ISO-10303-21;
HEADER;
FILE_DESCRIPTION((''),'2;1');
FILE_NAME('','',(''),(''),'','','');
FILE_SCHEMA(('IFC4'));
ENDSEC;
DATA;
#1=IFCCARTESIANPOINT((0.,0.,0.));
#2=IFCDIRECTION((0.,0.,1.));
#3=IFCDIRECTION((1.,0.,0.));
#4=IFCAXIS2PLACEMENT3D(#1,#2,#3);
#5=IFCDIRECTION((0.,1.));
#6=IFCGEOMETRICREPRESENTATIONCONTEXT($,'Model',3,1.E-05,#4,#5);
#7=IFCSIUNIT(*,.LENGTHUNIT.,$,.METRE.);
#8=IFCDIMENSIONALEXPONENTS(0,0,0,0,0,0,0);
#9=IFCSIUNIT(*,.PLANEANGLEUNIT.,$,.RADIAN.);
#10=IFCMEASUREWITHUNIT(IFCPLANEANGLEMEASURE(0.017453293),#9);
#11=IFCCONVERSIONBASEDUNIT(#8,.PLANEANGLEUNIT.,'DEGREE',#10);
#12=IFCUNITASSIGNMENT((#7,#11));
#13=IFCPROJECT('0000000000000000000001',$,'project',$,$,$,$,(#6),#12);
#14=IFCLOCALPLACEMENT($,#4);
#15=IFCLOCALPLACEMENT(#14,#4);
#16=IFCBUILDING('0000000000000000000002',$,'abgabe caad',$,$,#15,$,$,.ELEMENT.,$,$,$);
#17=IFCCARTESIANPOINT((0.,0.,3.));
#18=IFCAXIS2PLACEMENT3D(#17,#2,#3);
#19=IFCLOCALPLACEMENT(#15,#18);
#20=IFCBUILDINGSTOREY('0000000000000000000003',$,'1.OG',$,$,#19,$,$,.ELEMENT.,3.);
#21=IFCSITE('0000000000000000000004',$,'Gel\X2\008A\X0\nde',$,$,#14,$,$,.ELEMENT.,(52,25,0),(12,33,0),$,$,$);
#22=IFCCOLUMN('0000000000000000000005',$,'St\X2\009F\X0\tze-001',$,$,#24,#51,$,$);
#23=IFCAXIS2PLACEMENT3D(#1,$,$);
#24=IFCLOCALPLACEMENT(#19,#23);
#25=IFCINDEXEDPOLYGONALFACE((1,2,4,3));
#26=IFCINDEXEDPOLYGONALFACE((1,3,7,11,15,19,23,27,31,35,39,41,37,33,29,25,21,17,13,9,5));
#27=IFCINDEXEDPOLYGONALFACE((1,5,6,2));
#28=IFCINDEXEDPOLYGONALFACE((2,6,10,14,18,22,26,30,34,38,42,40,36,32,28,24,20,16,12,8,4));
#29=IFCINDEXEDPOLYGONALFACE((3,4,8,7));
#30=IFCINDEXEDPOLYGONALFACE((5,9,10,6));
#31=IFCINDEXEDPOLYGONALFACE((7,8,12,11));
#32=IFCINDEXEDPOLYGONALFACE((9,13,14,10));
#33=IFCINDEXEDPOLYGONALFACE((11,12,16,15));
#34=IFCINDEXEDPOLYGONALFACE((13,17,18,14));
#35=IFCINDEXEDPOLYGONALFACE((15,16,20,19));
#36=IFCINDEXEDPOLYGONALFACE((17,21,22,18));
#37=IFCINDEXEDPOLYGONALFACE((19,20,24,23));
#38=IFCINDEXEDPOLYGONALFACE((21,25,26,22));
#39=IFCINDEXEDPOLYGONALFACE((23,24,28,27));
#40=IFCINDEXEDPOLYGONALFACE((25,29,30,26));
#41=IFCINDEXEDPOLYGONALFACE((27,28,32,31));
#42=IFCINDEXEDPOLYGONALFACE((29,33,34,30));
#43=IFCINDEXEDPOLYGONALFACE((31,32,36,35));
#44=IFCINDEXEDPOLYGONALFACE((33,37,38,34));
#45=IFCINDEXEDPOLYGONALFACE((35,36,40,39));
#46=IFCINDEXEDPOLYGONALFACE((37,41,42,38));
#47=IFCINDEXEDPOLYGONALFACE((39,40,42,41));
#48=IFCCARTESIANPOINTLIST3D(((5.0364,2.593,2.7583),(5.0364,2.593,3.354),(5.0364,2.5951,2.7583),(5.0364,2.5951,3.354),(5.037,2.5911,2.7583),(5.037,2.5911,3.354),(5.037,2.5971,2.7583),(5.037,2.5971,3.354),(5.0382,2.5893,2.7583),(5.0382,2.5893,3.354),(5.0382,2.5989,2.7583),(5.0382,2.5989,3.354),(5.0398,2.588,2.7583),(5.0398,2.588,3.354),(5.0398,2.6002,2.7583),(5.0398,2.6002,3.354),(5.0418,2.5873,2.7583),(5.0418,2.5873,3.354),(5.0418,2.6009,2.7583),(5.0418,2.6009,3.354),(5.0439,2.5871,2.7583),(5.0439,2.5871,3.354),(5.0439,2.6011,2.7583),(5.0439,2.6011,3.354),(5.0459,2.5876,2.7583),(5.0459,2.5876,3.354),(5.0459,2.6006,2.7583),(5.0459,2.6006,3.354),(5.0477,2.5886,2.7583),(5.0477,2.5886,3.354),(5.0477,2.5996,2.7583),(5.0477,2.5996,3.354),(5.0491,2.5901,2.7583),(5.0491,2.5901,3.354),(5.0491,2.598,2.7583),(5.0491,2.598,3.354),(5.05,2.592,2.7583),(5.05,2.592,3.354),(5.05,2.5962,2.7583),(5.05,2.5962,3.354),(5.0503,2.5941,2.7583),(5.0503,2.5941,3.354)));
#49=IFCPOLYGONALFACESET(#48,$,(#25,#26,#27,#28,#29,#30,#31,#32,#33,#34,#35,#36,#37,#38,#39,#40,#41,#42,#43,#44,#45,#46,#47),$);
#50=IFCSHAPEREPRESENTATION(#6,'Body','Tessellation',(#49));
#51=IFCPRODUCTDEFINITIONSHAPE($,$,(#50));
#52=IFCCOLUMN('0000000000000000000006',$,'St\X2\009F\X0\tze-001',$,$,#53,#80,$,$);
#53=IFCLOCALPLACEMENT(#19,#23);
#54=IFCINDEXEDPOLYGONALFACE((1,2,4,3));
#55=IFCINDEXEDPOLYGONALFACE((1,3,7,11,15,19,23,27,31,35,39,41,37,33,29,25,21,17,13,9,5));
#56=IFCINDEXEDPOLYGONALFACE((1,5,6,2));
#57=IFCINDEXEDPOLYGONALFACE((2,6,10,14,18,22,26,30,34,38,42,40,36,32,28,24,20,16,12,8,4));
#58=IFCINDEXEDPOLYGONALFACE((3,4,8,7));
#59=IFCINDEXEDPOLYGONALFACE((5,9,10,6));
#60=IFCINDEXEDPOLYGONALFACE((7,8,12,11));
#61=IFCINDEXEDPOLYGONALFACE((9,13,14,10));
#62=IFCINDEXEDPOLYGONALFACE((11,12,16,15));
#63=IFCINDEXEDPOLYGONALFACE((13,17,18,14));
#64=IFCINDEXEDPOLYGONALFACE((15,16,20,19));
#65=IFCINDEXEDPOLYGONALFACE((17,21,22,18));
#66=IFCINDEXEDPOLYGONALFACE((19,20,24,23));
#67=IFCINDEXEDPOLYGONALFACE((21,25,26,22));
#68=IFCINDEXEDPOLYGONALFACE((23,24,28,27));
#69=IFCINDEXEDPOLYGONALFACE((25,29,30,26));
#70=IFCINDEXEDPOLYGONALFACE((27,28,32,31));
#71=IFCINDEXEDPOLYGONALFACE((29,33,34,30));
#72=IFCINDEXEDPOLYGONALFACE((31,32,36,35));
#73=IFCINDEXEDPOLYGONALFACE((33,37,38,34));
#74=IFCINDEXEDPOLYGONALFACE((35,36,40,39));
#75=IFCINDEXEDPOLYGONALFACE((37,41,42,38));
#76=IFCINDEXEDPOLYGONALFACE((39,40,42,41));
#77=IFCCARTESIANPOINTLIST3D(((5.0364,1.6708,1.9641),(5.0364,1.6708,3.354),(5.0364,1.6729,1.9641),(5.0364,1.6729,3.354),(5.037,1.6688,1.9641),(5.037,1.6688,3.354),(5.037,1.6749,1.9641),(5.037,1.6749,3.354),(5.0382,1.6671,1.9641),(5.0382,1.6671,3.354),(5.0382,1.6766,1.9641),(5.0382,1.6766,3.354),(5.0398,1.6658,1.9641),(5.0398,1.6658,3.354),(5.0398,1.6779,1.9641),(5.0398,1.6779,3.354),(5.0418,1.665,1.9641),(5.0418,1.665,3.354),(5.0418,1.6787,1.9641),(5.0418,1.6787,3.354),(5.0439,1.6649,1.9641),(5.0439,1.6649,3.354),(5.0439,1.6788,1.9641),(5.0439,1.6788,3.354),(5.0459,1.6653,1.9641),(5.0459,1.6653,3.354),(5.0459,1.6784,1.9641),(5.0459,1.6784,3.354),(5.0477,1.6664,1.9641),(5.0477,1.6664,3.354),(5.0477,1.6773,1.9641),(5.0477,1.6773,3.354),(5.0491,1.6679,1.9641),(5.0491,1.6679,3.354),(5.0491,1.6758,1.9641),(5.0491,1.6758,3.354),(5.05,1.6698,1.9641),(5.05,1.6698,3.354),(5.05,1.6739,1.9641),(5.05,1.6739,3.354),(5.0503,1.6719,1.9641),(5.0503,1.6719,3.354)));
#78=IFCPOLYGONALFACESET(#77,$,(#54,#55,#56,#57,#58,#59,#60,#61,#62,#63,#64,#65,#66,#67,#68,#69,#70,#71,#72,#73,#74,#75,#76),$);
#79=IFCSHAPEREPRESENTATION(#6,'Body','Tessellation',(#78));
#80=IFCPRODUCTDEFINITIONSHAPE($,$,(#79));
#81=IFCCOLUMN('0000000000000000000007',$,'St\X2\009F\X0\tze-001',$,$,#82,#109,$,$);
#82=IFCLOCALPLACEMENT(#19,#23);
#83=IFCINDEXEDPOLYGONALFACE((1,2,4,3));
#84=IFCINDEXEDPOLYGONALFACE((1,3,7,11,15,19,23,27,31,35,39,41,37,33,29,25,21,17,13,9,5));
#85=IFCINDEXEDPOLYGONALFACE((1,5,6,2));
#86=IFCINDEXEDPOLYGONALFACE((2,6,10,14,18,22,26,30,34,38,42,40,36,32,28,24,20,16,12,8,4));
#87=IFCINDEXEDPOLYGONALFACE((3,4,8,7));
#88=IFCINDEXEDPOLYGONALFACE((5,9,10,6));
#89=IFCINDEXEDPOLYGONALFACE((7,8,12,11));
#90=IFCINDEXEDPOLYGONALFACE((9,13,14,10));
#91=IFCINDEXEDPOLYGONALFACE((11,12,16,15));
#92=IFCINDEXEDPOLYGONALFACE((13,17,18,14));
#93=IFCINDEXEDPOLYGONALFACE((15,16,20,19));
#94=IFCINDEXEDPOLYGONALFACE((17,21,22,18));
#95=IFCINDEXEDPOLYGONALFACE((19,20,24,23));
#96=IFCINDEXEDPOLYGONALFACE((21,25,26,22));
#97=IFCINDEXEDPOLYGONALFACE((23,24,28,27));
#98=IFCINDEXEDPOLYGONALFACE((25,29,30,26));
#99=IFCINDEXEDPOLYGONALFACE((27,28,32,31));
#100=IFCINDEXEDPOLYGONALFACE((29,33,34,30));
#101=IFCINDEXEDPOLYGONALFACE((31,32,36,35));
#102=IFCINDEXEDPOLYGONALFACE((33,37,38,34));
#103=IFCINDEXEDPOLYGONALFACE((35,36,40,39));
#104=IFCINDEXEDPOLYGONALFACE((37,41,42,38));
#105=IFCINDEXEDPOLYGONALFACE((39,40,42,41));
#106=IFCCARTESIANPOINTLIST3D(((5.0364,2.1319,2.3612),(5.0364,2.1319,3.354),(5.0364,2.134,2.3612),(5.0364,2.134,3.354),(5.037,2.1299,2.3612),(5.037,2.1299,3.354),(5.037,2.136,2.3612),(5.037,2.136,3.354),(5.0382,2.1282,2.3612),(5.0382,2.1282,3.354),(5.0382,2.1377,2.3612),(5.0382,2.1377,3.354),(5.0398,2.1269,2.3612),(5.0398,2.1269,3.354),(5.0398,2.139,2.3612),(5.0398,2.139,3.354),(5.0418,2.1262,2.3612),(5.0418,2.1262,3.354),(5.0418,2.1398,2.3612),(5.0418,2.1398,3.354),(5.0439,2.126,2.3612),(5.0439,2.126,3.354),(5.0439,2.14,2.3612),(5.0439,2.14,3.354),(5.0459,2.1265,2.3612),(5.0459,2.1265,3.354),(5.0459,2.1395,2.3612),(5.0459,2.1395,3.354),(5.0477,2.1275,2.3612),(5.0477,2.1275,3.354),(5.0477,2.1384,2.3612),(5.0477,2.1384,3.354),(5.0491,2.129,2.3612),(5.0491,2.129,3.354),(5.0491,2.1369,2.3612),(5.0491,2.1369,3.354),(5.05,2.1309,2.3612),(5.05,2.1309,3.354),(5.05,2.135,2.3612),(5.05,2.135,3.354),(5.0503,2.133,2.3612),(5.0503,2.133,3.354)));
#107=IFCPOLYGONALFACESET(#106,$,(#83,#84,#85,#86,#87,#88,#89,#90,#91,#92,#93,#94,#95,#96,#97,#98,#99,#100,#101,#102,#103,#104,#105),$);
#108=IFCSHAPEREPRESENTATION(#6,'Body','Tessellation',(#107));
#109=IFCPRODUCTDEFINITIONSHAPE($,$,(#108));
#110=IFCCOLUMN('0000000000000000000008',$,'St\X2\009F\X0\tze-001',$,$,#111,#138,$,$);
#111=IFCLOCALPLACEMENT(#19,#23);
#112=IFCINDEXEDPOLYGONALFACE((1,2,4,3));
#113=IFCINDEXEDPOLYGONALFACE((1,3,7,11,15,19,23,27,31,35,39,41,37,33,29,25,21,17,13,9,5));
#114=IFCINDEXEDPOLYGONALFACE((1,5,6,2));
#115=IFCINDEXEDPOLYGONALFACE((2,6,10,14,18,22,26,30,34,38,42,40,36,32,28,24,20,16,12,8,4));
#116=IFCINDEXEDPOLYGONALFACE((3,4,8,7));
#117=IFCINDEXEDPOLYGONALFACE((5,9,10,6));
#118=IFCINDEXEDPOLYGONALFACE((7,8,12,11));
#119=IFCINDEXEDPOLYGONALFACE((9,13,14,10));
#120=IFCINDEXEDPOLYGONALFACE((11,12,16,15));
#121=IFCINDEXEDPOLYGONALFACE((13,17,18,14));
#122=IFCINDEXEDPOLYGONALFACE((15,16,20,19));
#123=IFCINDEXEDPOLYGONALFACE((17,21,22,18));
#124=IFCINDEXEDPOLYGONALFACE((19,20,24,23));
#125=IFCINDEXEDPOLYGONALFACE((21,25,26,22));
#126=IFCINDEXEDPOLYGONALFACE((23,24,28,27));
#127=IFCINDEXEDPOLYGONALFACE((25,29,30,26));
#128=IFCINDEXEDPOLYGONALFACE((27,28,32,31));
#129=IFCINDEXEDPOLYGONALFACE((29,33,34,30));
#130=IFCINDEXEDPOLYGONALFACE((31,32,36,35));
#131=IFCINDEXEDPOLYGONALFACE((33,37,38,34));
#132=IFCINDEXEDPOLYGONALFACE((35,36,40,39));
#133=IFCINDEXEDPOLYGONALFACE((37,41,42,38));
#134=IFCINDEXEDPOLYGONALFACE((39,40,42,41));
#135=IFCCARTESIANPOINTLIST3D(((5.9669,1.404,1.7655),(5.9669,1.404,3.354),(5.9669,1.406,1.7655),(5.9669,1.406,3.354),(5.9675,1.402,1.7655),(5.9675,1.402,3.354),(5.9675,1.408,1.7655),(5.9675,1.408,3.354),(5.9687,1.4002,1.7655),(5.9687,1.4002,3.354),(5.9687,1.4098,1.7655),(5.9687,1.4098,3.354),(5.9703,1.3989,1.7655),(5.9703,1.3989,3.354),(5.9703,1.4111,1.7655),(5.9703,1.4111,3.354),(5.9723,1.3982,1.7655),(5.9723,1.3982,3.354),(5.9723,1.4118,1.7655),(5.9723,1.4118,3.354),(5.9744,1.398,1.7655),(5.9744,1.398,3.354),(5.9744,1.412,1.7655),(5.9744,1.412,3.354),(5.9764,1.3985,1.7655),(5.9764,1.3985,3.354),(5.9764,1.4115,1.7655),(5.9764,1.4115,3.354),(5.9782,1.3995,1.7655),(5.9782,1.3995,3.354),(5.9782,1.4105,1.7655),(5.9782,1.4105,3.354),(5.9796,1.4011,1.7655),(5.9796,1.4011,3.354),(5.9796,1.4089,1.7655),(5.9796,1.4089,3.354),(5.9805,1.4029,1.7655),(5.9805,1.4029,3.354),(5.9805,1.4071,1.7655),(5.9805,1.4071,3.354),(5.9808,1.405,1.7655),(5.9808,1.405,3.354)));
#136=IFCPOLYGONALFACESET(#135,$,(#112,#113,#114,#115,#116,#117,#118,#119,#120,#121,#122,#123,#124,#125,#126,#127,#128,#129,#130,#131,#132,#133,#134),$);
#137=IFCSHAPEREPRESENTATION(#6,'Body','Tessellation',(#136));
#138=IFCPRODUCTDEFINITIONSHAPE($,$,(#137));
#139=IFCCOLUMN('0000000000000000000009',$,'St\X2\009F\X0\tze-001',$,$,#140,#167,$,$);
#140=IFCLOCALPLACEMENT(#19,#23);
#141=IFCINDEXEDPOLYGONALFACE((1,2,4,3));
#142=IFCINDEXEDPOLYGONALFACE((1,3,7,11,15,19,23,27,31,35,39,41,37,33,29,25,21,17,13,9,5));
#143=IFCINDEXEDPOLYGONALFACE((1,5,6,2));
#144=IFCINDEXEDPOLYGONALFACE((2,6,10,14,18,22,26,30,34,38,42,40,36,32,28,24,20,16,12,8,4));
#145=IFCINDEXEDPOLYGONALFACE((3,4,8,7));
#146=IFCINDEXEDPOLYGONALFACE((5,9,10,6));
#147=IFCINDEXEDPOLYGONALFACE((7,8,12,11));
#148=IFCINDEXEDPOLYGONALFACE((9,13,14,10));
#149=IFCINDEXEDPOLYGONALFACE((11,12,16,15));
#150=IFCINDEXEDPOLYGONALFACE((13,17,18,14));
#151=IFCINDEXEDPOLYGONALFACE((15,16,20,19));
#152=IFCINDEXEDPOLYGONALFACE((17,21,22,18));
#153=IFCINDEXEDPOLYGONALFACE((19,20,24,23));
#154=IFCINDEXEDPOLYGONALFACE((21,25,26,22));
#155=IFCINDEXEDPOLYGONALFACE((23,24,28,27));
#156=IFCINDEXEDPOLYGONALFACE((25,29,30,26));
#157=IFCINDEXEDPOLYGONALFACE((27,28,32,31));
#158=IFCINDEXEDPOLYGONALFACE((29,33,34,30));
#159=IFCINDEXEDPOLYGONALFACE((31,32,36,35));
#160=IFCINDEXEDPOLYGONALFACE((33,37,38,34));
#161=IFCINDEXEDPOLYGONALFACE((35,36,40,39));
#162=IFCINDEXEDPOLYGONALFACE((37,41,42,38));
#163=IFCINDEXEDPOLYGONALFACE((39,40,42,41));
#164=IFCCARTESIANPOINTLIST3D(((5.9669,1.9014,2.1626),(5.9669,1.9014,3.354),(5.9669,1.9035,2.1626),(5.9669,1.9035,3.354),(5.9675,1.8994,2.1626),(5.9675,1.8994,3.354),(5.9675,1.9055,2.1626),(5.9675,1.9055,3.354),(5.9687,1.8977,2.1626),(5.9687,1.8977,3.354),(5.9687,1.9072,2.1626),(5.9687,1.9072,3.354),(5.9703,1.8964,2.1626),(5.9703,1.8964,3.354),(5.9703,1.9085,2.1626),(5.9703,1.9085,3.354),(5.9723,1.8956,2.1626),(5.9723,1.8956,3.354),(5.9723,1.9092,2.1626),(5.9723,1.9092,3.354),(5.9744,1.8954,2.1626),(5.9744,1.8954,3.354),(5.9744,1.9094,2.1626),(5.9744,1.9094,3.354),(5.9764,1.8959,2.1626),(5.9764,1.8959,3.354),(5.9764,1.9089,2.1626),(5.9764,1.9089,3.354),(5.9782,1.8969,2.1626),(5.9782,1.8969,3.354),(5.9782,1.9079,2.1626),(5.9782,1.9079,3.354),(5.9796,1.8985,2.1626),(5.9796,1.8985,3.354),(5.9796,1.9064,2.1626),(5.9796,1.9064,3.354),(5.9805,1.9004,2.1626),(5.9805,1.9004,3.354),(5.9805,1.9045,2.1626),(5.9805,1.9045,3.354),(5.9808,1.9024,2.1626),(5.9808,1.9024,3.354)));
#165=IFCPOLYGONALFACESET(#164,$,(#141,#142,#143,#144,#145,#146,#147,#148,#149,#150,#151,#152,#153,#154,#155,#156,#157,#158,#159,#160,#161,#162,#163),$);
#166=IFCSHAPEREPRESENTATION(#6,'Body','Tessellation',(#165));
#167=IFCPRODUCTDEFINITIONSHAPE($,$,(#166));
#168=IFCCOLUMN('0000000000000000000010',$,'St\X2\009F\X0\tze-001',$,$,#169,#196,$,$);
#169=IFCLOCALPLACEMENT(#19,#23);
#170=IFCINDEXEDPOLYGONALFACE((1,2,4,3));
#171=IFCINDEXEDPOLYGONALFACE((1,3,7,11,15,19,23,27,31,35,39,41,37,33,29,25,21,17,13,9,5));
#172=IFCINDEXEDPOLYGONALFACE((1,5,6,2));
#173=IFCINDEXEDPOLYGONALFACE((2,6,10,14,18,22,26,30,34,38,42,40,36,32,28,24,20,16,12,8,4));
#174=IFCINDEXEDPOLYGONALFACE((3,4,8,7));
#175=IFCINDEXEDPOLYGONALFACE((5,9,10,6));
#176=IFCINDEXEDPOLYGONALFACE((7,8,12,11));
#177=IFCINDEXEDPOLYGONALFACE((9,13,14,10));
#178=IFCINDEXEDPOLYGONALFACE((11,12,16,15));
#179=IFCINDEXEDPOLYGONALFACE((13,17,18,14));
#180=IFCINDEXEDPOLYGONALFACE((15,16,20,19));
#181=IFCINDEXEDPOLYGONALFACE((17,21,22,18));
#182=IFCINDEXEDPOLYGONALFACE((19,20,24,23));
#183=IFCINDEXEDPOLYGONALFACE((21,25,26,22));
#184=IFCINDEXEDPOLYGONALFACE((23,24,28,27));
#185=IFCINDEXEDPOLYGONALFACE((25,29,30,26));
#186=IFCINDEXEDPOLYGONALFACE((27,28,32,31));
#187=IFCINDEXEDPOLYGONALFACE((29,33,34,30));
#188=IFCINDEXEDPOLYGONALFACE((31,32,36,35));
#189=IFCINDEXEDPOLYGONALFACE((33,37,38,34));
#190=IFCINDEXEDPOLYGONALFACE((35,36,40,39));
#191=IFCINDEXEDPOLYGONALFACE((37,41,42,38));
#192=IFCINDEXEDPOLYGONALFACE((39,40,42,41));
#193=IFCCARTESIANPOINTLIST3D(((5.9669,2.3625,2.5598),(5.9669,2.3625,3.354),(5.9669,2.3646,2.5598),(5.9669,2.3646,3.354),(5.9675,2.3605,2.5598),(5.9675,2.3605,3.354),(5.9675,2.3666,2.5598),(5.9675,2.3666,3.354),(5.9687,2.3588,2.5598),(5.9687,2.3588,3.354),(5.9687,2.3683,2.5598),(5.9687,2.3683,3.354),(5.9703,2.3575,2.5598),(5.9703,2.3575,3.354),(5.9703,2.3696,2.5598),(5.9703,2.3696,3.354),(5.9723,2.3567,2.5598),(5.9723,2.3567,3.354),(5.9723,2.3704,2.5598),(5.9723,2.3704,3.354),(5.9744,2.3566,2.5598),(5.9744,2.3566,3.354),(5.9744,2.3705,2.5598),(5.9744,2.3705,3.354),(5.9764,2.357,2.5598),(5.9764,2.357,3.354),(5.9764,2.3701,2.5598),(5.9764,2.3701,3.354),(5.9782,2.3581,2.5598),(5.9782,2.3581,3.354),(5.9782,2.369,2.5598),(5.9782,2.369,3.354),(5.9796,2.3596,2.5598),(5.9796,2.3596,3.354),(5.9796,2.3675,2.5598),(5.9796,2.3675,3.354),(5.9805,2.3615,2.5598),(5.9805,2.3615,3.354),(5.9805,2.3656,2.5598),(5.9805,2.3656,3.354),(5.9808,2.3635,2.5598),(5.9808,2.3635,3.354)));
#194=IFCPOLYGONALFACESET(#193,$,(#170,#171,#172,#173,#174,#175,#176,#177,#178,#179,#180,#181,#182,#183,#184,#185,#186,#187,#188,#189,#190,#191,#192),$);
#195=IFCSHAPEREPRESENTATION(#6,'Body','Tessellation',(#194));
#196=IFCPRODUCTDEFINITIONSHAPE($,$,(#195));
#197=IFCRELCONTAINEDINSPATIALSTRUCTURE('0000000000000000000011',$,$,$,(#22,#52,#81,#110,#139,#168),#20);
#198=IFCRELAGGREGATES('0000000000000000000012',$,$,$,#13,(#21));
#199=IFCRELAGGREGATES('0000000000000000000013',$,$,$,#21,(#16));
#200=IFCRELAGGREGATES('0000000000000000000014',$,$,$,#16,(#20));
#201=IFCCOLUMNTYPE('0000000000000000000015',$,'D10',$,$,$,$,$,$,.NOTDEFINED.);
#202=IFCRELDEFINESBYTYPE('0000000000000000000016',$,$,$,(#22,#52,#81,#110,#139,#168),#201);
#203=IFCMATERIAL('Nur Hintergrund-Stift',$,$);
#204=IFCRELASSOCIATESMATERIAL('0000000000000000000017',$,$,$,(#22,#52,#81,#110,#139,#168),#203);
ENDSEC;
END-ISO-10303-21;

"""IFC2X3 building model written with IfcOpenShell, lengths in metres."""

from ifc_helpers import new_model, entity, si_unit, converted_unit, direction, frame, origin_with_axes, origin_2d_with_axis, place, context, project, spatial, circle, extrude, material, type_object, element, save


model = new_model("IFC2X3")

# Units and contexts
model_context = context("Model", 3, precision=1e-05, world=origin_with_axes(), true_north=direction((0.0, 1.0)))
ifc_project = project(units=[si_unit("LENGTHUNIT", "METRE"), converted_unit("PLANEANGLEUNIT", "DEGREE", entity("IfcPlaneAngleMeasure", 0.017453293), si_unit("PLANEANGLEUNIT", "RADIAN"), dimensions=[0, 0, 0, 0, 0, 0, 0])], contexts=[model_context])

# Site, building, storey
site_placement = place(None, origin_with_axes())
site = spatial("IfcSite", under=ifc_project, at=site_placement, Name="Gel\u008ande", CompositionType="ELEMENT", RefLatitude=(52, 25, 0), RefLongitude=(12, 33, 0))
building_placement = place(site_placement, origin_with_axes())
building = spatial("IfcBuilding", under=site, at=building_placement, Name="abgabe caad", CompositionType="ELEMENT")
storey_placement = place(building_placement, frame((0.0, 0.0, 3.0), z_axis=(0.0, 0.0, 1.0), x_axis=(1.0, 0.0, 0.0)))
storey = spatial("IfcBuildingStorey", under=building, at=storey_placement, Name="1.OG", CompositionType="ELEMENT", Elevation=3.0)

# Columns
ifc_material_1 = material(Name="Nur Hintergrund-Stift")
column_type = type_object("IfcColumnType", Name="D10", PredefinedType="NOTDEFINED")
column_1_placement = place(storey_placement, frame((5.0433, 2.5941, 2.7583), z_axis=(0.0, 0.0, 1.0), x_axis=(1.0, 0.0, 0.0)))
element("IfcColumn", 1, at=column_1_placement, inside=storey, type_object=column_type, material=ifc_material_1, Name="St\u009ftze-001", context=model_context, shape_type="SweptSolid", body=[
    extrude(circle(Radius=0.007, at=origin_2d_with_axis()), origin_with_axes(), (0.0, 0.0, 1.0), 0.5957),
])
column_2_placement = place(storey_placement, frame((5.0433, 1.6719, 1.9641), z_axis=(0.0, 0.0, 1.0), x_axis=(1.0, 0.0, 0.0)))
element("IfcColumn", 2, at=column_2_placement, inside=storey, type_object=column_type, material=ifc_material_1, Name="St\u009ftze-001", context=model_context, shape_type="SweptSolid", body=[
    extrude(circle(Radius=0.007, at=origin_2d_with_axis()), origin_with_axes(), (0.0, 0.0, 1.0), 1.3899),
])
column_3_placement = place(storey_placement, frame((5.0433, 2.133, 2.3612), z_axis=(0.0, 0.0, 1.0), x_axis=(1.0, 0.0, 0.0)))
element("IfcColumn", 3, at=column_3_placement, inside=storey, type_object=column_type, material=ifc_material_1, Name="St\u009ftze-001", context=model_context, shape_type="SweptSolid", body=[
    extrude(circle(Radius=0.007, at=origin_2d_with_axis()), origin_with_axes(), (0.0, 0.0, 1.0), 0.9928),
])
column_4_placement = place(storey_placement, frame((5.9738, 1.405, 1.7655), z_axis=(0.0, 0.0, 1.0), x_axis=(1.0, 0.0, 0.0)))
element("IfcColumn", 4, at=column_4_placement, inside=storey, type_object=column_type, material=ifc_material_1, Name="St\u009ftze-001", context=model_context, shape_type="SweptSolid", body=[
    extrude(circle(Radius=0.007, at=origin_2d_with_axis()), origin_with_axes(), (0.0, 0.0, 1.0), 1.5885),
])
column_5_placement = place(storey_placement, frame((5.9738, 1.9024, 2.1626), z_axis=(0.0, 0.0, 1.0), x_axis=(1.0, 0.0, 0.0)))
element("IfcColumn", 5, at=column_5_placement, inside=storey, type_object=column_type, material=ifc_material_1, Name="St\u009ftze-001", context=model_context, shape_type="SweptSolid", body=[
    extrude(circle(Radius=0.007, at=origin_2d_with_axis()), origin_with_axes(), (0.0, 0.0, 1.0), 1.1914),
])
column_6_placement = place(storey_placement, frame((5.9738, 2.3635, 2.5598), z_axis=(0.0, 0.0, 1.0), x_axis=(1.0, 0.0, 0.0)))
element("IfcColumn", 6, at=column_6_placement, inside=storey, type_object=column_type, material=ifc_material_1, Name="St\u009ftze-001", context=model_context, shape_type="SweptSolid", body=[
    extrude(circle(Radius=0.007, at=origin_2d_with_axis()), origin_with_axes(), (0.0, 0.0, 1.0), 0.7943),
])

save(model, "model.ifc")
